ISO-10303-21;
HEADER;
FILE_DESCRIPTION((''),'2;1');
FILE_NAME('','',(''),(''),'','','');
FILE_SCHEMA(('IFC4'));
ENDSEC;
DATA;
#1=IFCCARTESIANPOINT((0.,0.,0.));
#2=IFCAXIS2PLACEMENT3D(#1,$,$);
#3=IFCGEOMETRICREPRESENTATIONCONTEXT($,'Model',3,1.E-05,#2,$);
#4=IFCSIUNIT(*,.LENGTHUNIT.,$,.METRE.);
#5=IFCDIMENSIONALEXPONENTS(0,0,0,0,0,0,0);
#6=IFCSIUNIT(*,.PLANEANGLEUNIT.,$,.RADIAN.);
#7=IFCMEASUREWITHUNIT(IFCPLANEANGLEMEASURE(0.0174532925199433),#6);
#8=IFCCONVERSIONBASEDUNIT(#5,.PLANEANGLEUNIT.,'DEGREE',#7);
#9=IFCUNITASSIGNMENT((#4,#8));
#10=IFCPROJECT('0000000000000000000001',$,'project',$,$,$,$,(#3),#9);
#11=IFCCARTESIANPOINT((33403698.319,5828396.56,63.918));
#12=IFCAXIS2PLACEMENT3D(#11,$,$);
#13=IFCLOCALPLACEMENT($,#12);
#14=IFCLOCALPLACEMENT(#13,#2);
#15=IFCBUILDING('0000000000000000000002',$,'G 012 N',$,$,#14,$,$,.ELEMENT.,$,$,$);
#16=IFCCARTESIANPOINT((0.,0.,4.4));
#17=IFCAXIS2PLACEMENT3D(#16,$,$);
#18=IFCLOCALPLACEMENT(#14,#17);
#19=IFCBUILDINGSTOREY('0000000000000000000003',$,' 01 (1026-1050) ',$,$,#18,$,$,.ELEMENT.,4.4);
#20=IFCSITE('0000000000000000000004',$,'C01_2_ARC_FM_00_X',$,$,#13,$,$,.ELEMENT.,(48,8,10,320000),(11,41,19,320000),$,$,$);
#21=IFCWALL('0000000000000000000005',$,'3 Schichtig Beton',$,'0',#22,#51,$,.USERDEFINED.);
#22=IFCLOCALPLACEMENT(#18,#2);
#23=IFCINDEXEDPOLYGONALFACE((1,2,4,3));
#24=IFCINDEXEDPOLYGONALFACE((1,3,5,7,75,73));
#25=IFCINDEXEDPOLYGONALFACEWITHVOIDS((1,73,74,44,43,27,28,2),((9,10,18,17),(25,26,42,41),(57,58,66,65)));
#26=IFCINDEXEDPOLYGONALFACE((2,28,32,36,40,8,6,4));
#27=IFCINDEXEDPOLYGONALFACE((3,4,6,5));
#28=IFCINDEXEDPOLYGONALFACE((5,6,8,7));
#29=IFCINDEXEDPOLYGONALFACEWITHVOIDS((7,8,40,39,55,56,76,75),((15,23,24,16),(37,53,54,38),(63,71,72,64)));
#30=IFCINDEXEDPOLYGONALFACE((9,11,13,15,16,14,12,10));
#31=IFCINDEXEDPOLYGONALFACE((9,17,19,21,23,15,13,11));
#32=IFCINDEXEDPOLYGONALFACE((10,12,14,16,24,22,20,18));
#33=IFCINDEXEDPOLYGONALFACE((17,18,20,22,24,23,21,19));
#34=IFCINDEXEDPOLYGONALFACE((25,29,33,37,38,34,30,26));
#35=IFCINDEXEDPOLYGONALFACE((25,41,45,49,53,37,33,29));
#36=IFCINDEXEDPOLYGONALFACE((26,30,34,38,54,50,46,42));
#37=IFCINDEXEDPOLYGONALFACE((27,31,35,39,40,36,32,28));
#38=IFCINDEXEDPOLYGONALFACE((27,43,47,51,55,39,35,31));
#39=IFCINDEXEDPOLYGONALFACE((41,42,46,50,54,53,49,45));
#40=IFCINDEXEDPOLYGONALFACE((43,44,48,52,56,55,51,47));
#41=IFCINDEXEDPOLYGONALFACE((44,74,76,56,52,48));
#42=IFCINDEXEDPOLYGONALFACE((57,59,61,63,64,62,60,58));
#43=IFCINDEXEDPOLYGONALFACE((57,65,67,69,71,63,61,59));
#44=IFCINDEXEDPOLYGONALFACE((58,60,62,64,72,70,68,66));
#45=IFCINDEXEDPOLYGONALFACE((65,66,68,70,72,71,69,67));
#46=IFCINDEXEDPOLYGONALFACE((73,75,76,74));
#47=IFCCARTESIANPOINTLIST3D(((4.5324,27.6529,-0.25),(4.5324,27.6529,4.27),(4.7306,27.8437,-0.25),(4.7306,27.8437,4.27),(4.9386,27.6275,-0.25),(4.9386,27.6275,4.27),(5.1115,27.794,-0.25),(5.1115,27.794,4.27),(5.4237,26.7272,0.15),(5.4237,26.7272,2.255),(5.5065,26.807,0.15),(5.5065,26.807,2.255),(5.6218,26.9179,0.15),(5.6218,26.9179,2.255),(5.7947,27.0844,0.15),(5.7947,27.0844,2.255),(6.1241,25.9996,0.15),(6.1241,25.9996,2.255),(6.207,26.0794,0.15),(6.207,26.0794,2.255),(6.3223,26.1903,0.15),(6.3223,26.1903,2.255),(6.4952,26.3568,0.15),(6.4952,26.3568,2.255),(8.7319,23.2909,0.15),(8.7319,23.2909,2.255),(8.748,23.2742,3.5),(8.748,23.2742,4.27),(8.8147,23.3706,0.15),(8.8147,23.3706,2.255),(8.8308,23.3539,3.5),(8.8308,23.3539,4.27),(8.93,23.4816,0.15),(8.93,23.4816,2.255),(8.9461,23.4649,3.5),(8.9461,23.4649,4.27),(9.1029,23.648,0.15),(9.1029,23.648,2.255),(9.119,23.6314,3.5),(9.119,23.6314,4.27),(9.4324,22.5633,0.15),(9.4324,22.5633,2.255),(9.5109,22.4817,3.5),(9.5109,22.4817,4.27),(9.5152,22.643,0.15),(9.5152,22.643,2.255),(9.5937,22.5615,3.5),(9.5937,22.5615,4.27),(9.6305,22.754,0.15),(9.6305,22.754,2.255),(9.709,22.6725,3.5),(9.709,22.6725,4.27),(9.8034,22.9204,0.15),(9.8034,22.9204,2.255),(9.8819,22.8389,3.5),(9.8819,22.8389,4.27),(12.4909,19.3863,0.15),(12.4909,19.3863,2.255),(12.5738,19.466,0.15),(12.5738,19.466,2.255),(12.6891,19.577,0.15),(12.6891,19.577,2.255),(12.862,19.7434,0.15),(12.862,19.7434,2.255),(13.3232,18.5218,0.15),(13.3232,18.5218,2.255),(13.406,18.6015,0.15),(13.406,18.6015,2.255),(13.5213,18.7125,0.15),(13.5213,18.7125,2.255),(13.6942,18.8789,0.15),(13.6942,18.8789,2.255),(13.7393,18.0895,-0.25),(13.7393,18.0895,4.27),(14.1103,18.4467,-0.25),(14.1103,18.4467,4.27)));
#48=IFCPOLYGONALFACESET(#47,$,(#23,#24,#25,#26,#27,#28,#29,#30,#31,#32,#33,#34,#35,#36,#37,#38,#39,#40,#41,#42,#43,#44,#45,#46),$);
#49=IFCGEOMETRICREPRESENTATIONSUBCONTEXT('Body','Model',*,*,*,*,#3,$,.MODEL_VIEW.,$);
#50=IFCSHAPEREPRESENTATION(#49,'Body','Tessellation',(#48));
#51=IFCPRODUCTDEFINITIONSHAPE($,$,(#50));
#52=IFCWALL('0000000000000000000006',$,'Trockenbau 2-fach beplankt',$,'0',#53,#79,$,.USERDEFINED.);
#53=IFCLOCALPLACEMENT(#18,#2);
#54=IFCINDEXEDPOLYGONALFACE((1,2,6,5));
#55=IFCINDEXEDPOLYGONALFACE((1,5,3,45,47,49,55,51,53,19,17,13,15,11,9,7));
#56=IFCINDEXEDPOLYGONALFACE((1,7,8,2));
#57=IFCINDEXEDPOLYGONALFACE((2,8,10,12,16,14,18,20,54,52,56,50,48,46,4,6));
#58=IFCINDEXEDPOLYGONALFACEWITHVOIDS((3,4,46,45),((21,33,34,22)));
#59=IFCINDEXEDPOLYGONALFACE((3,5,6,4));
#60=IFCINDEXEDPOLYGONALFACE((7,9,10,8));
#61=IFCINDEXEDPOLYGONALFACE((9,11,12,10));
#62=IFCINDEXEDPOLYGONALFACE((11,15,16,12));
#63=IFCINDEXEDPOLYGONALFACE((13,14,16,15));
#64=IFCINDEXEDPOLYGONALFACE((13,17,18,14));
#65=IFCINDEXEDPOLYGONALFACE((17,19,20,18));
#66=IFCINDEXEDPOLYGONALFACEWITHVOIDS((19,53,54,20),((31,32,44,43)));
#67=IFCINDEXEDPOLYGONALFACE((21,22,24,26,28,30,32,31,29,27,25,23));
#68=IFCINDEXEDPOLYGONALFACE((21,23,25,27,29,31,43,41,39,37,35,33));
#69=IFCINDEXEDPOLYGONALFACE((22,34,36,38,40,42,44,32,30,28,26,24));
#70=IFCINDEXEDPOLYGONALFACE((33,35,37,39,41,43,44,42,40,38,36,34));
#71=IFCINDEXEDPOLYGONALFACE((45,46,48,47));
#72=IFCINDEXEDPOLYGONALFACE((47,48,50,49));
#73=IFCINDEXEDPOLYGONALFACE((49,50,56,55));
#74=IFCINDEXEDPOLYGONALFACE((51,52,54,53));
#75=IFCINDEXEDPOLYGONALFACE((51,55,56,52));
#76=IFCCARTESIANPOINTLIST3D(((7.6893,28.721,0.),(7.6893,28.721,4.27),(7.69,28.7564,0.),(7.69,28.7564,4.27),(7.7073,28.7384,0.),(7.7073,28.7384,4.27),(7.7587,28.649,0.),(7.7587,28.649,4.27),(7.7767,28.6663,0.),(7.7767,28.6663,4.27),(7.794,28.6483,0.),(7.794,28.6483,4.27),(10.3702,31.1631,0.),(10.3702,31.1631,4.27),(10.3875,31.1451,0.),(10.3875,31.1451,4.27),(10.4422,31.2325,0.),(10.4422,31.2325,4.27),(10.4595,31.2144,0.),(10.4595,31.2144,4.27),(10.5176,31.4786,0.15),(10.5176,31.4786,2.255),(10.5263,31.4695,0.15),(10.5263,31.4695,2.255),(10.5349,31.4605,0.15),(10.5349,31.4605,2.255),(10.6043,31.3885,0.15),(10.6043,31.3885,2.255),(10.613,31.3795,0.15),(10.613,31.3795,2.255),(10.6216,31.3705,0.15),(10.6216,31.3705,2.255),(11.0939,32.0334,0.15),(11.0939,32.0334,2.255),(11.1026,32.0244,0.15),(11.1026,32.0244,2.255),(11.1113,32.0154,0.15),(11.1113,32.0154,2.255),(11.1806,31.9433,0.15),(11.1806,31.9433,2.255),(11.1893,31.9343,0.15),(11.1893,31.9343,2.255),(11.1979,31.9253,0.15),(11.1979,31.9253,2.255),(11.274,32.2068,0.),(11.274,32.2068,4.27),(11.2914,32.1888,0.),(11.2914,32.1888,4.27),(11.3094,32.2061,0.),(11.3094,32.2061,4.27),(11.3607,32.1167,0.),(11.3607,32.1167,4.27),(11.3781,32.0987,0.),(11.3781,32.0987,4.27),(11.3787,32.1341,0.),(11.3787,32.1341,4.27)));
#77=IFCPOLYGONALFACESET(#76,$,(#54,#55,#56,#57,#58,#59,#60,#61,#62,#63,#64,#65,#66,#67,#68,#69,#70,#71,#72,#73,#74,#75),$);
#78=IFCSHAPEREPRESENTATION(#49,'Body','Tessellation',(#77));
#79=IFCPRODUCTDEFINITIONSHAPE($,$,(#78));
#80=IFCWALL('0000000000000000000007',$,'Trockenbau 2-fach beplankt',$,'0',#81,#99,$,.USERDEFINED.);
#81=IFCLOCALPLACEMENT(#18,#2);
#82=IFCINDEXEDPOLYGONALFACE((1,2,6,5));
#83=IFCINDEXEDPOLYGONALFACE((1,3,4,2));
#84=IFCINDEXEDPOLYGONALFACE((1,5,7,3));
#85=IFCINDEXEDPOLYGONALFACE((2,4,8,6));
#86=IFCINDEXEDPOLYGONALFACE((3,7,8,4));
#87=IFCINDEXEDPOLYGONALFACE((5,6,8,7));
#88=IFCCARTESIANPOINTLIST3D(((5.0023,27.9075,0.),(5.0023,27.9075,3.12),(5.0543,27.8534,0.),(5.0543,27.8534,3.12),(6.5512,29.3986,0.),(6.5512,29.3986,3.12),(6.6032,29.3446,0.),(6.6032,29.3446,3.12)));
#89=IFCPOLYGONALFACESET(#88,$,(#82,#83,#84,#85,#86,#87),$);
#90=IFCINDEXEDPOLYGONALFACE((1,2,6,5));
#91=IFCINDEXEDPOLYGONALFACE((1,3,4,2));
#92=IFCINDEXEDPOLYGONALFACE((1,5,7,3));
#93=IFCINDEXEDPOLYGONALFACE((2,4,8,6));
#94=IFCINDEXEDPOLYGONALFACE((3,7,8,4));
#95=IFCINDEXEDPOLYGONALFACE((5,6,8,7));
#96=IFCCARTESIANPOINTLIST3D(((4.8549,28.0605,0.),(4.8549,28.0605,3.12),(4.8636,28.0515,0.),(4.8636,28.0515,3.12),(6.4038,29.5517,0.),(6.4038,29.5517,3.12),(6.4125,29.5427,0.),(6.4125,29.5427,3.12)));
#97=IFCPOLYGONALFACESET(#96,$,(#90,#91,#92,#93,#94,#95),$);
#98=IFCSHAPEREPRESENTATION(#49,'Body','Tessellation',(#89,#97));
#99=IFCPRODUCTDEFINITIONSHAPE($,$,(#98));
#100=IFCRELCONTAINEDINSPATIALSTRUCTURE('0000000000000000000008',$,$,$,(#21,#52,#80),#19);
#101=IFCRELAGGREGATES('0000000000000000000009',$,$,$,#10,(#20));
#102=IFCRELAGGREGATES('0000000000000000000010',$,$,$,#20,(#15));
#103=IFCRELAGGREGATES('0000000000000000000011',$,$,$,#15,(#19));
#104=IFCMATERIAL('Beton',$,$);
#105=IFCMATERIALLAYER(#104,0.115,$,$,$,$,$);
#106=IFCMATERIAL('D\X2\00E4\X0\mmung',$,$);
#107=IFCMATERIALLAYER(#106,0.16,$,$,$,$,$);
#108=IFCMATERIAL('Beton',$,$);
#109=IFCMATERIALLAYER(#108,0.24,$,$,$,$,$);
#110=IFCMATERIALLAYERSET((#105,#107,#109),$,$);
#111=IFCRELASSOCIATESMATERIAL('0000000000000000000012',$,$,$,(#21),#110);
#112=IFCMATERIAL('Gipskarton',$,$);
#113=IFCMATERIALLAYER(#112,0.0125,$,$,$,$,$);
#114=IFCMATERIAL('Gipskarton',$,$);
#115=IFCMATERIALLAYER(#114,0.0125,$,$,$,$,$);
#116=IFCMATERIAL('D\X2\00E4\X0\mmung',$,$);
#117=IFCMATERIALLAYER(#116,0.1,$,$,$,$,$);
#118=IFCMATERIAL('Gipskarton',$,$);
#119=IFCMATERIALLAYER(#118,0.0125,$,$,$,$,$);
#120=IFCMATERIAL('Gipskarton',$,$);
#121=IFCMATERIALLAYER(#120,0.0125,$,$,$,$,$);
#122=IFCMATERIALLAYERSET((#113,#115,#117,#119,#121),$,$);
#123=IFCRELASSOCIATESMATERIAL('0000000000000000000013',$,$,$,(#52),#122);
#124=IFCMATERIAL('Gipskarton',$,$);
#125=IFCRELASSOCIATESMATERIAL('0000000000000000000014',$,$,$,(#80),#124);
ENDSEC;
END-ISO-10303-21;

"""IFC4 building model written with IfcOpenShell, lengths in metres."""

from ifc_helpers import new_model, entity, si_unit, converted_unit, frame, frame_2d, origin, origin_with_axes, place, context, subcontext, project, spatial, polyline, rectangle, outline, extrude, material, layer, layer_set, layer_usage, element, save


model = new_model("IFC4")

# Units and contexts
model_context = context("Model", 3, precision=1e-05, world=origin())
body_context = subcontext(model_context, "Body", "Model", "MODEL_VIEW")
ifc_project = project(units=[si_unit("LENGTHUNIT", "METRE"), converted_unit("PLANEANGLEUNIT", "DEGREE", entity("IfcPlaneAngleMeasure", 0.0174532925199433), si_unit("PLANEANGLEUNIT", "RADIAN"), dimensions=[0, 0, 0, 0, 0, 0, 0])], contexts=[model_context])

# Site, building, storey
site_placement = place(None, frame((33403698.319, 5828396.56, 63.918)))
site = spatial("IfcSite", under=ifc_project, at=site_placement, Name="C01_2_ARC_FM_00_X", CompositionType="ELEMENT", RefLatitude=(48, 8, 10, 320000), RefLongitude=(11, 41, 19, 320000))
building_placement = place(site_placement, origin())
building = spatial("IfcBuilding", under=site, at=building_placement, Name="G 012 N", CompositionType="ELEMENT")
storey_placement = place(building_placement, frame((0.0, 0.0, 4.4)))
storey = spatial("IfcBuildingStorey", under=building, at=storey_placement, Name=" 01 (1026-1050) ", CompositionType="ELEMENT", Elevation=4.4)

# Wall, openings
ifc_material_1 = material(Name="Beton")
ifc_layer_1 = layer(ifc_material_1, 0.115)
ifc_material_2 = material(Name="Dämmung")
ifc_layer_2 = layer(ifc_material_2, 0.16)
ifc_material_3 = material(Name="Beton")
ifc_layer_3 = layer(ifc_material_3, 0.24)
ifc_layer_set_1 = layer_set([ifc_layer_1, ifc_layer_2, ifc_layer_3])
ifc_layer_usage_1 = layer_usage(ifc_layer_set_1, "AXIS2", "POSITIVE", 0.0)
wall_1_placement = place(storey_placement, frame((4.5324, 27.6529, -0.25), z_axis=(0.0, 0.0, 1.0), x_axis=(0.693551, -0.720408, 0.0)))
wall_1 = element("IfcWall", 1, at=wall_1_placement, inside=storey, material=ifc_layer_usage_1, Name="3 Schichtig Beton", ObjectType="0", PredefinedType="USERDEFINED", context=body_context, shape_type="SweptSolid", body=[
    extrude(outline(polyline([(-6.5896, 7.1477), (-6.5896, 6.9077), (-6.8896, 6.9077), (-6.8896, 6.6327), (6.3854, 6.6327), (6.3854, 7.1477), (-6.5896, 7.1477)])), frame((6.8896, -6.6327, 0.0), z_axis=(0.0, 0.0, 1.0), x_axis=(1.0, 0.0, 0.0)), (0.0, 0.0, 1.0), 4.52),
])
opening_1_placement = place(wall_1_placement, frame((7.065, 0.115, 0.4), z_axis=(0.0, -1.0, 0.0), x_axis=(0.0, 0.0, 1.0)))
element("IfcOpeningElement", 2, at=opening_1_placement, cuts=wall_1, ObjectType="0", PredefinedType="USERDEFINED", context=body_context, shape_type="SweptSolid", body=[
    extrude(outline(polyline([(0.0, 1.01), (2.105, 1.01), (2.105, 0.0), (0.0, 0.0), (0.0, 1.01)])), origin_with_axes(), (0.0, 0.0, 1.0), 0.115),
    extrude(outline(polyline([(0.0, 1.01), (2.105, 1.01), (2.105, 0.0), (0.0, 0.0), (0.0, 1.01)])), frame((0.0, 0.0, -0.16), z_axis=(0.0, 0.0, 1.0), x_axis=(1.0, 0.0, 0.0)), (0.0, 0.0, 1.0), 0.16),
    extrude(outline(polyline([(0.0, 1.01), (2.105, 1.01), (2.105, 0.0), (0.0, 0.0), (0.0, 1.01)])), frame((0.0, 0.0, -0.4), z_axis=(0.0, 0.0, 1.0), x_axis=(1.0, 0.0, 0.0)), (0.0, 0.0, 1.0), 0.24),
])
opening_2_placement = place(wall_1_placement, frame((7.1782, 0.515, 3.75), z_axis=(0.0, -1.0, 0.0), x_axis=(0.0, 0.0, 1.0)))
element("IfcOpeningElement", 3, at=opening_2_placement, cuts=wall_1, ObjectType="0", PredefinedType="USERDEFINED", context=body_context, shape_type="SweptSolid", body=[
    extrude(outline(polyline([(0.0, 1.1), (0.77, 1.1), (0.77, 0.0), (0.0, 0.0), (0.0, 1.1)])), origin_with_axes(), (0.0, 0.0, 1.0), 0.24),
    extrude(outline(polyline([(0.0, 1.1), (0.77, 1.1), (0.77, 0.0), (0.0, 0.0), (0.0, 1.1)])), frame((0.0, 0.0, 0.24), z_axis=(0.0, 0.0, 1.0), x_axis=(1.0, 0.0, 0.0)), (0.0, 0.0, 1.0), 0.16),
    extrude(outline(polyline([(0.0, 1.1), (0.77, 1.1), (0.77, 0.0), (0.0, 0.0), (0.0, 1.1)])), frame((0.0, 0.0, 0.4), z_axis=(0.0, 0.0, 1.0), x_axis=(1.0, 0.0, 0.0)), (0.0, 0.0, 1.0), 0.115),
])
opening_3_placement = place(wall_1_placement, frame((2.295, 0.115, 0.4), z_axis=(0.0, -1.0, 0.0), x_axis=(0.0, 0.0, 1.0)))
element("IfcOpeningElement", 4, at=opening_3_placement, cuts=wall_1, ObjectType="0", PredefinedType="USERDEFINED", context=body_context, shape_type="SweptSolid", body=[
    extrude(outline(polyline([(0.0, 1.01), (2.105, 1.01), (2.105, 0.0), (0.0, 0.0), (0.0, 1.01)])), origin_with_axes(), (0.0, 0.0, 1.0), 0.115),
    extrude(outline(polyline([(0.0, 1.01), (2.105, 1.01), (2.105, 0.0), (0.0, 0.0), (0.0, 1.01)])), frame((0.0, 0.0, -0.16), z_axis=(0.0, 0.0, 1.0), x_axis=(1.0, 0.0, 0.0)), (0.0, 0.0, 1.0), 0.16),
    extrude(outline(polyline([(0.0, 1.01), (2.105, 1.01), (2.105, 0.0), (0.0, 0.0), (0.0, 1.01)])), frame((0.0, 0.0, -0.4), z_axis=(0.0, 0.0, 1.0), x_axis=(1.0, 0.0, 0.0)), (0.0, 0.0, 1.0), 0.24),
])
opening_4_placement = place(wall_1_placement, frame((12.675, 0.115, 0.4), z_axis=(0.0, -1.0, 0.0), x_axis=(0.0, 0.0, 1.0)))
element("IfcOpeningElement", 5, at=opening_4_placement, cuts=wall_1, ObjectType="0", PredefinedType="USERDEFINED", context=body_context, shape_type="SweptSolid", body=[
    extrude(outline(polyline([(0.0, 1.2), (2.105, 1.2), (2.105, 0.0), (0.0, 0.0), (0.0, 1.2)])), origin_with_axes(), (0.0, 0.0, 1.0), 0.115),
    extrude(outline(polyline([(0.0, 1.2), (2.105, 1.2), (2.105, 0.0), (0.0, 0.0), (0.0, 1.2)])), frame((0.0, 0.0, -0.16), z_axis=(0.0, 0.0, 1.0), x_axis=(1.0, 0.0, 0.0)), (0.0, 0.0, 1.0), 0.16),
    extrude(outline(polyline([(0.0, 1.2), (2.105, 1.2), (2.105, 0.0), (0.0, 0.0), (0.0, 1.2)])), frame((0.0, 0.0, -0.4), z_axis=(0.0, 0.0, 1.0), x_axis=(1.0, 0.0, 0.0)), (0.0, 0.0, 1.0), 0.24),
])

# Wall, opening
ifc_material_4 = material(Name="Gipskarton")
ifc_layer_4 = layer(ifc_material_4, 0.0125)
ifc_material_5 = material(Name="Gipskarton")
ifc_layer_5 = layer(ifc_material_5, 0.0125)
ifc_material_6 = material(Name="Dämmung")
ifc_layer_6 = layer(ifc_material_6, 0.1)
ifc_material_7 = material(Name="Gipskarton")
ifc_layer_7 = layer(ifc_material_7, 0.0125)
ifc_material_8 = material(Name="Gipskarton")
ifc_layer_8 = layer(ifc_material_8, 0.0125)
ifc_layer_set_2 = layer_set([ifc_layer_4, ifc_layer_5, ifc_layer_6, ifc_layer_7, ifc_layer_8])
ifc_layer_usage_2 = layer_usage(ifc_layer_set_2, "AXIS2", "POSITIVE", 0.0)
wall_2_placement = place(storey_placement, frame((7.794, 28.6483, 0.0), z_axis=(0.0, 0.0, 1.0), x_axis=(0.720408, 0.693551, 0.0)))
wall_2 = element("IfcWall", 6, at=wall_2_placement, inside=storey, material=ifc_layer_usage_2, Name="Trockenbau 2-fach beplankt", ObjectType="0", PredefinedType="USERDEFINED", context=body_context, shape_type="SweptSolid", body=[
    extrude(outline(polyline([(5.0504, -0.0726), (5.0504, -0.0476), (5.0754, -0.0476), (5.0754, 0.0524), (5.0504, 0.0524), (5.0504, 0.0774), (0.0754, 0.0774), (0.0754, 0.0524), (0.0504, 0.0524), (0.0504, -0.0476), (0.0754, -0.0476), (0.0754, -0.0726), (3.6754, -0.0726), (3.6754, -0.0476), (3.7754, -0.0476), (3.7754, -0.0726), (5.0504, -0.0726)])), frame((-0.0754, 0.0726, 0.0), z_axis=(0.0, 0.0, 1.0), x_axis=(1.0, 0.0, 0.0)), (0.0, 0.0, 1.0), 4.27),
])
opening_5_placement = place(wall_2_placement, frame((3.925, 0.0, 0.15), z_axis=(0.0, 1.0, 0.0), x_axis=(0.0, 0.0, 1.0)))
element("IfcOpeningElement", 7, at=opening_5_placement, cuts=wall_2, ObjectType="0", PredefinedType="USERDEFINED", context=body_context, shape_type="SweptSolid", body=[
    extrude(outline(polyline([(0.0, 0.8), (2.105, 0.8), (2.105, 0.0), (0.0, 0.0), (0.0, 0.8)])), origin_with_axes(), (0.0, 0.0, 1.0), 0.0125),
    extrude(outline(polyline([(0.0, 0.8), (2.105, 0.8), (2.105, 0.0), (0.0, 0.0), (0.0, 0.8)])), frame((0.0, 0.0, 0.0125), z_axis=(0.0, 0.0, 1.0), x_axis=(1.0, 0.0, 0.0)), (0.0, 0.0, 1.0), 0.0125),
    extrude(outline(polyline([(0.0, 0.8), (2.105, 0.8), (2.105, 0.0), (0.0, 0.0), (0.0, 0.8)])), frame((0.0, 0.0, 0.025), z_axis=(0.0, 0.0, 1.0), x_axis=(1.0, 0.0, 0.0)), (0.0, 0.0, 1.0), 0.1),
    extrude(outline(polyline([(0.0, 0.8), (2.105, 0.8), (2.105, 0.0), (0.0, 0.0), (0.0, 0.8)])), frame((0.0, 0.0, 0.125), z_axis=(0.0, 0.0, 1.0), x_axis=(1.0, 0.0, 0.0)), (0.0, 0.0, 1.0), 0.0125),
    extrude(outline(polyline([(0.0, 0.8), (2.105, 0.8), (2.105, 0.0), (0.0, 0.0), (0.0, 0.8)])), frame((0.0, 0.0, 0.1375), z_axis=(0.0, 0.0, 1.0), x_axis=(1.0, 0.0, 0.0)), (0.0, 0.0, 1.0), 0.0125),
])

# Wall
ifc_material_9 = material(Name="Gipskarton")
wall_3_placement = place(storey_placement, frame((6.4038, 29.5517, 0.0), z_axis=(0.0, 0.0, 1.0), x_axis=(-0.720408, -0.693551, 0.0)))
element("IfcWall", 8, at=wall_3_placement, inside=storey, material=ifc_material_9, Name="Trockenbau 2-fach beplankt", ObjectType="0", PredefinedType="USERDEFINED", context=body_context, shape_type="SweptSolid", body=[
    extrude(rectangle(XDim=0.075, YDim=2.15, at=frame_2d((1.075, -0.0375), x_axis=(0.0, -1.0))), frame((0.0, 0.2875, 0.0), z_axis=(0.0, 0.0, 1.0), x_axis=(1.0, 0.0, 0.0)), (0.0, 0.0, 1.0), 3.12),
    extrude(rectangle(XDim=2.15, YDim=0.0125, at=frame_2d((-1.075, -0.0062), x_axis=(-1.0, 0.0))), frame((2.15, 0.0125, 0.0), z_axis=(0.0, 0.0, 1.0), x_axis=(1.0, 0.0, 0.0)), (0.0, 0.0, 1.0), 3.12),
])

save(model, "model.ifc")
